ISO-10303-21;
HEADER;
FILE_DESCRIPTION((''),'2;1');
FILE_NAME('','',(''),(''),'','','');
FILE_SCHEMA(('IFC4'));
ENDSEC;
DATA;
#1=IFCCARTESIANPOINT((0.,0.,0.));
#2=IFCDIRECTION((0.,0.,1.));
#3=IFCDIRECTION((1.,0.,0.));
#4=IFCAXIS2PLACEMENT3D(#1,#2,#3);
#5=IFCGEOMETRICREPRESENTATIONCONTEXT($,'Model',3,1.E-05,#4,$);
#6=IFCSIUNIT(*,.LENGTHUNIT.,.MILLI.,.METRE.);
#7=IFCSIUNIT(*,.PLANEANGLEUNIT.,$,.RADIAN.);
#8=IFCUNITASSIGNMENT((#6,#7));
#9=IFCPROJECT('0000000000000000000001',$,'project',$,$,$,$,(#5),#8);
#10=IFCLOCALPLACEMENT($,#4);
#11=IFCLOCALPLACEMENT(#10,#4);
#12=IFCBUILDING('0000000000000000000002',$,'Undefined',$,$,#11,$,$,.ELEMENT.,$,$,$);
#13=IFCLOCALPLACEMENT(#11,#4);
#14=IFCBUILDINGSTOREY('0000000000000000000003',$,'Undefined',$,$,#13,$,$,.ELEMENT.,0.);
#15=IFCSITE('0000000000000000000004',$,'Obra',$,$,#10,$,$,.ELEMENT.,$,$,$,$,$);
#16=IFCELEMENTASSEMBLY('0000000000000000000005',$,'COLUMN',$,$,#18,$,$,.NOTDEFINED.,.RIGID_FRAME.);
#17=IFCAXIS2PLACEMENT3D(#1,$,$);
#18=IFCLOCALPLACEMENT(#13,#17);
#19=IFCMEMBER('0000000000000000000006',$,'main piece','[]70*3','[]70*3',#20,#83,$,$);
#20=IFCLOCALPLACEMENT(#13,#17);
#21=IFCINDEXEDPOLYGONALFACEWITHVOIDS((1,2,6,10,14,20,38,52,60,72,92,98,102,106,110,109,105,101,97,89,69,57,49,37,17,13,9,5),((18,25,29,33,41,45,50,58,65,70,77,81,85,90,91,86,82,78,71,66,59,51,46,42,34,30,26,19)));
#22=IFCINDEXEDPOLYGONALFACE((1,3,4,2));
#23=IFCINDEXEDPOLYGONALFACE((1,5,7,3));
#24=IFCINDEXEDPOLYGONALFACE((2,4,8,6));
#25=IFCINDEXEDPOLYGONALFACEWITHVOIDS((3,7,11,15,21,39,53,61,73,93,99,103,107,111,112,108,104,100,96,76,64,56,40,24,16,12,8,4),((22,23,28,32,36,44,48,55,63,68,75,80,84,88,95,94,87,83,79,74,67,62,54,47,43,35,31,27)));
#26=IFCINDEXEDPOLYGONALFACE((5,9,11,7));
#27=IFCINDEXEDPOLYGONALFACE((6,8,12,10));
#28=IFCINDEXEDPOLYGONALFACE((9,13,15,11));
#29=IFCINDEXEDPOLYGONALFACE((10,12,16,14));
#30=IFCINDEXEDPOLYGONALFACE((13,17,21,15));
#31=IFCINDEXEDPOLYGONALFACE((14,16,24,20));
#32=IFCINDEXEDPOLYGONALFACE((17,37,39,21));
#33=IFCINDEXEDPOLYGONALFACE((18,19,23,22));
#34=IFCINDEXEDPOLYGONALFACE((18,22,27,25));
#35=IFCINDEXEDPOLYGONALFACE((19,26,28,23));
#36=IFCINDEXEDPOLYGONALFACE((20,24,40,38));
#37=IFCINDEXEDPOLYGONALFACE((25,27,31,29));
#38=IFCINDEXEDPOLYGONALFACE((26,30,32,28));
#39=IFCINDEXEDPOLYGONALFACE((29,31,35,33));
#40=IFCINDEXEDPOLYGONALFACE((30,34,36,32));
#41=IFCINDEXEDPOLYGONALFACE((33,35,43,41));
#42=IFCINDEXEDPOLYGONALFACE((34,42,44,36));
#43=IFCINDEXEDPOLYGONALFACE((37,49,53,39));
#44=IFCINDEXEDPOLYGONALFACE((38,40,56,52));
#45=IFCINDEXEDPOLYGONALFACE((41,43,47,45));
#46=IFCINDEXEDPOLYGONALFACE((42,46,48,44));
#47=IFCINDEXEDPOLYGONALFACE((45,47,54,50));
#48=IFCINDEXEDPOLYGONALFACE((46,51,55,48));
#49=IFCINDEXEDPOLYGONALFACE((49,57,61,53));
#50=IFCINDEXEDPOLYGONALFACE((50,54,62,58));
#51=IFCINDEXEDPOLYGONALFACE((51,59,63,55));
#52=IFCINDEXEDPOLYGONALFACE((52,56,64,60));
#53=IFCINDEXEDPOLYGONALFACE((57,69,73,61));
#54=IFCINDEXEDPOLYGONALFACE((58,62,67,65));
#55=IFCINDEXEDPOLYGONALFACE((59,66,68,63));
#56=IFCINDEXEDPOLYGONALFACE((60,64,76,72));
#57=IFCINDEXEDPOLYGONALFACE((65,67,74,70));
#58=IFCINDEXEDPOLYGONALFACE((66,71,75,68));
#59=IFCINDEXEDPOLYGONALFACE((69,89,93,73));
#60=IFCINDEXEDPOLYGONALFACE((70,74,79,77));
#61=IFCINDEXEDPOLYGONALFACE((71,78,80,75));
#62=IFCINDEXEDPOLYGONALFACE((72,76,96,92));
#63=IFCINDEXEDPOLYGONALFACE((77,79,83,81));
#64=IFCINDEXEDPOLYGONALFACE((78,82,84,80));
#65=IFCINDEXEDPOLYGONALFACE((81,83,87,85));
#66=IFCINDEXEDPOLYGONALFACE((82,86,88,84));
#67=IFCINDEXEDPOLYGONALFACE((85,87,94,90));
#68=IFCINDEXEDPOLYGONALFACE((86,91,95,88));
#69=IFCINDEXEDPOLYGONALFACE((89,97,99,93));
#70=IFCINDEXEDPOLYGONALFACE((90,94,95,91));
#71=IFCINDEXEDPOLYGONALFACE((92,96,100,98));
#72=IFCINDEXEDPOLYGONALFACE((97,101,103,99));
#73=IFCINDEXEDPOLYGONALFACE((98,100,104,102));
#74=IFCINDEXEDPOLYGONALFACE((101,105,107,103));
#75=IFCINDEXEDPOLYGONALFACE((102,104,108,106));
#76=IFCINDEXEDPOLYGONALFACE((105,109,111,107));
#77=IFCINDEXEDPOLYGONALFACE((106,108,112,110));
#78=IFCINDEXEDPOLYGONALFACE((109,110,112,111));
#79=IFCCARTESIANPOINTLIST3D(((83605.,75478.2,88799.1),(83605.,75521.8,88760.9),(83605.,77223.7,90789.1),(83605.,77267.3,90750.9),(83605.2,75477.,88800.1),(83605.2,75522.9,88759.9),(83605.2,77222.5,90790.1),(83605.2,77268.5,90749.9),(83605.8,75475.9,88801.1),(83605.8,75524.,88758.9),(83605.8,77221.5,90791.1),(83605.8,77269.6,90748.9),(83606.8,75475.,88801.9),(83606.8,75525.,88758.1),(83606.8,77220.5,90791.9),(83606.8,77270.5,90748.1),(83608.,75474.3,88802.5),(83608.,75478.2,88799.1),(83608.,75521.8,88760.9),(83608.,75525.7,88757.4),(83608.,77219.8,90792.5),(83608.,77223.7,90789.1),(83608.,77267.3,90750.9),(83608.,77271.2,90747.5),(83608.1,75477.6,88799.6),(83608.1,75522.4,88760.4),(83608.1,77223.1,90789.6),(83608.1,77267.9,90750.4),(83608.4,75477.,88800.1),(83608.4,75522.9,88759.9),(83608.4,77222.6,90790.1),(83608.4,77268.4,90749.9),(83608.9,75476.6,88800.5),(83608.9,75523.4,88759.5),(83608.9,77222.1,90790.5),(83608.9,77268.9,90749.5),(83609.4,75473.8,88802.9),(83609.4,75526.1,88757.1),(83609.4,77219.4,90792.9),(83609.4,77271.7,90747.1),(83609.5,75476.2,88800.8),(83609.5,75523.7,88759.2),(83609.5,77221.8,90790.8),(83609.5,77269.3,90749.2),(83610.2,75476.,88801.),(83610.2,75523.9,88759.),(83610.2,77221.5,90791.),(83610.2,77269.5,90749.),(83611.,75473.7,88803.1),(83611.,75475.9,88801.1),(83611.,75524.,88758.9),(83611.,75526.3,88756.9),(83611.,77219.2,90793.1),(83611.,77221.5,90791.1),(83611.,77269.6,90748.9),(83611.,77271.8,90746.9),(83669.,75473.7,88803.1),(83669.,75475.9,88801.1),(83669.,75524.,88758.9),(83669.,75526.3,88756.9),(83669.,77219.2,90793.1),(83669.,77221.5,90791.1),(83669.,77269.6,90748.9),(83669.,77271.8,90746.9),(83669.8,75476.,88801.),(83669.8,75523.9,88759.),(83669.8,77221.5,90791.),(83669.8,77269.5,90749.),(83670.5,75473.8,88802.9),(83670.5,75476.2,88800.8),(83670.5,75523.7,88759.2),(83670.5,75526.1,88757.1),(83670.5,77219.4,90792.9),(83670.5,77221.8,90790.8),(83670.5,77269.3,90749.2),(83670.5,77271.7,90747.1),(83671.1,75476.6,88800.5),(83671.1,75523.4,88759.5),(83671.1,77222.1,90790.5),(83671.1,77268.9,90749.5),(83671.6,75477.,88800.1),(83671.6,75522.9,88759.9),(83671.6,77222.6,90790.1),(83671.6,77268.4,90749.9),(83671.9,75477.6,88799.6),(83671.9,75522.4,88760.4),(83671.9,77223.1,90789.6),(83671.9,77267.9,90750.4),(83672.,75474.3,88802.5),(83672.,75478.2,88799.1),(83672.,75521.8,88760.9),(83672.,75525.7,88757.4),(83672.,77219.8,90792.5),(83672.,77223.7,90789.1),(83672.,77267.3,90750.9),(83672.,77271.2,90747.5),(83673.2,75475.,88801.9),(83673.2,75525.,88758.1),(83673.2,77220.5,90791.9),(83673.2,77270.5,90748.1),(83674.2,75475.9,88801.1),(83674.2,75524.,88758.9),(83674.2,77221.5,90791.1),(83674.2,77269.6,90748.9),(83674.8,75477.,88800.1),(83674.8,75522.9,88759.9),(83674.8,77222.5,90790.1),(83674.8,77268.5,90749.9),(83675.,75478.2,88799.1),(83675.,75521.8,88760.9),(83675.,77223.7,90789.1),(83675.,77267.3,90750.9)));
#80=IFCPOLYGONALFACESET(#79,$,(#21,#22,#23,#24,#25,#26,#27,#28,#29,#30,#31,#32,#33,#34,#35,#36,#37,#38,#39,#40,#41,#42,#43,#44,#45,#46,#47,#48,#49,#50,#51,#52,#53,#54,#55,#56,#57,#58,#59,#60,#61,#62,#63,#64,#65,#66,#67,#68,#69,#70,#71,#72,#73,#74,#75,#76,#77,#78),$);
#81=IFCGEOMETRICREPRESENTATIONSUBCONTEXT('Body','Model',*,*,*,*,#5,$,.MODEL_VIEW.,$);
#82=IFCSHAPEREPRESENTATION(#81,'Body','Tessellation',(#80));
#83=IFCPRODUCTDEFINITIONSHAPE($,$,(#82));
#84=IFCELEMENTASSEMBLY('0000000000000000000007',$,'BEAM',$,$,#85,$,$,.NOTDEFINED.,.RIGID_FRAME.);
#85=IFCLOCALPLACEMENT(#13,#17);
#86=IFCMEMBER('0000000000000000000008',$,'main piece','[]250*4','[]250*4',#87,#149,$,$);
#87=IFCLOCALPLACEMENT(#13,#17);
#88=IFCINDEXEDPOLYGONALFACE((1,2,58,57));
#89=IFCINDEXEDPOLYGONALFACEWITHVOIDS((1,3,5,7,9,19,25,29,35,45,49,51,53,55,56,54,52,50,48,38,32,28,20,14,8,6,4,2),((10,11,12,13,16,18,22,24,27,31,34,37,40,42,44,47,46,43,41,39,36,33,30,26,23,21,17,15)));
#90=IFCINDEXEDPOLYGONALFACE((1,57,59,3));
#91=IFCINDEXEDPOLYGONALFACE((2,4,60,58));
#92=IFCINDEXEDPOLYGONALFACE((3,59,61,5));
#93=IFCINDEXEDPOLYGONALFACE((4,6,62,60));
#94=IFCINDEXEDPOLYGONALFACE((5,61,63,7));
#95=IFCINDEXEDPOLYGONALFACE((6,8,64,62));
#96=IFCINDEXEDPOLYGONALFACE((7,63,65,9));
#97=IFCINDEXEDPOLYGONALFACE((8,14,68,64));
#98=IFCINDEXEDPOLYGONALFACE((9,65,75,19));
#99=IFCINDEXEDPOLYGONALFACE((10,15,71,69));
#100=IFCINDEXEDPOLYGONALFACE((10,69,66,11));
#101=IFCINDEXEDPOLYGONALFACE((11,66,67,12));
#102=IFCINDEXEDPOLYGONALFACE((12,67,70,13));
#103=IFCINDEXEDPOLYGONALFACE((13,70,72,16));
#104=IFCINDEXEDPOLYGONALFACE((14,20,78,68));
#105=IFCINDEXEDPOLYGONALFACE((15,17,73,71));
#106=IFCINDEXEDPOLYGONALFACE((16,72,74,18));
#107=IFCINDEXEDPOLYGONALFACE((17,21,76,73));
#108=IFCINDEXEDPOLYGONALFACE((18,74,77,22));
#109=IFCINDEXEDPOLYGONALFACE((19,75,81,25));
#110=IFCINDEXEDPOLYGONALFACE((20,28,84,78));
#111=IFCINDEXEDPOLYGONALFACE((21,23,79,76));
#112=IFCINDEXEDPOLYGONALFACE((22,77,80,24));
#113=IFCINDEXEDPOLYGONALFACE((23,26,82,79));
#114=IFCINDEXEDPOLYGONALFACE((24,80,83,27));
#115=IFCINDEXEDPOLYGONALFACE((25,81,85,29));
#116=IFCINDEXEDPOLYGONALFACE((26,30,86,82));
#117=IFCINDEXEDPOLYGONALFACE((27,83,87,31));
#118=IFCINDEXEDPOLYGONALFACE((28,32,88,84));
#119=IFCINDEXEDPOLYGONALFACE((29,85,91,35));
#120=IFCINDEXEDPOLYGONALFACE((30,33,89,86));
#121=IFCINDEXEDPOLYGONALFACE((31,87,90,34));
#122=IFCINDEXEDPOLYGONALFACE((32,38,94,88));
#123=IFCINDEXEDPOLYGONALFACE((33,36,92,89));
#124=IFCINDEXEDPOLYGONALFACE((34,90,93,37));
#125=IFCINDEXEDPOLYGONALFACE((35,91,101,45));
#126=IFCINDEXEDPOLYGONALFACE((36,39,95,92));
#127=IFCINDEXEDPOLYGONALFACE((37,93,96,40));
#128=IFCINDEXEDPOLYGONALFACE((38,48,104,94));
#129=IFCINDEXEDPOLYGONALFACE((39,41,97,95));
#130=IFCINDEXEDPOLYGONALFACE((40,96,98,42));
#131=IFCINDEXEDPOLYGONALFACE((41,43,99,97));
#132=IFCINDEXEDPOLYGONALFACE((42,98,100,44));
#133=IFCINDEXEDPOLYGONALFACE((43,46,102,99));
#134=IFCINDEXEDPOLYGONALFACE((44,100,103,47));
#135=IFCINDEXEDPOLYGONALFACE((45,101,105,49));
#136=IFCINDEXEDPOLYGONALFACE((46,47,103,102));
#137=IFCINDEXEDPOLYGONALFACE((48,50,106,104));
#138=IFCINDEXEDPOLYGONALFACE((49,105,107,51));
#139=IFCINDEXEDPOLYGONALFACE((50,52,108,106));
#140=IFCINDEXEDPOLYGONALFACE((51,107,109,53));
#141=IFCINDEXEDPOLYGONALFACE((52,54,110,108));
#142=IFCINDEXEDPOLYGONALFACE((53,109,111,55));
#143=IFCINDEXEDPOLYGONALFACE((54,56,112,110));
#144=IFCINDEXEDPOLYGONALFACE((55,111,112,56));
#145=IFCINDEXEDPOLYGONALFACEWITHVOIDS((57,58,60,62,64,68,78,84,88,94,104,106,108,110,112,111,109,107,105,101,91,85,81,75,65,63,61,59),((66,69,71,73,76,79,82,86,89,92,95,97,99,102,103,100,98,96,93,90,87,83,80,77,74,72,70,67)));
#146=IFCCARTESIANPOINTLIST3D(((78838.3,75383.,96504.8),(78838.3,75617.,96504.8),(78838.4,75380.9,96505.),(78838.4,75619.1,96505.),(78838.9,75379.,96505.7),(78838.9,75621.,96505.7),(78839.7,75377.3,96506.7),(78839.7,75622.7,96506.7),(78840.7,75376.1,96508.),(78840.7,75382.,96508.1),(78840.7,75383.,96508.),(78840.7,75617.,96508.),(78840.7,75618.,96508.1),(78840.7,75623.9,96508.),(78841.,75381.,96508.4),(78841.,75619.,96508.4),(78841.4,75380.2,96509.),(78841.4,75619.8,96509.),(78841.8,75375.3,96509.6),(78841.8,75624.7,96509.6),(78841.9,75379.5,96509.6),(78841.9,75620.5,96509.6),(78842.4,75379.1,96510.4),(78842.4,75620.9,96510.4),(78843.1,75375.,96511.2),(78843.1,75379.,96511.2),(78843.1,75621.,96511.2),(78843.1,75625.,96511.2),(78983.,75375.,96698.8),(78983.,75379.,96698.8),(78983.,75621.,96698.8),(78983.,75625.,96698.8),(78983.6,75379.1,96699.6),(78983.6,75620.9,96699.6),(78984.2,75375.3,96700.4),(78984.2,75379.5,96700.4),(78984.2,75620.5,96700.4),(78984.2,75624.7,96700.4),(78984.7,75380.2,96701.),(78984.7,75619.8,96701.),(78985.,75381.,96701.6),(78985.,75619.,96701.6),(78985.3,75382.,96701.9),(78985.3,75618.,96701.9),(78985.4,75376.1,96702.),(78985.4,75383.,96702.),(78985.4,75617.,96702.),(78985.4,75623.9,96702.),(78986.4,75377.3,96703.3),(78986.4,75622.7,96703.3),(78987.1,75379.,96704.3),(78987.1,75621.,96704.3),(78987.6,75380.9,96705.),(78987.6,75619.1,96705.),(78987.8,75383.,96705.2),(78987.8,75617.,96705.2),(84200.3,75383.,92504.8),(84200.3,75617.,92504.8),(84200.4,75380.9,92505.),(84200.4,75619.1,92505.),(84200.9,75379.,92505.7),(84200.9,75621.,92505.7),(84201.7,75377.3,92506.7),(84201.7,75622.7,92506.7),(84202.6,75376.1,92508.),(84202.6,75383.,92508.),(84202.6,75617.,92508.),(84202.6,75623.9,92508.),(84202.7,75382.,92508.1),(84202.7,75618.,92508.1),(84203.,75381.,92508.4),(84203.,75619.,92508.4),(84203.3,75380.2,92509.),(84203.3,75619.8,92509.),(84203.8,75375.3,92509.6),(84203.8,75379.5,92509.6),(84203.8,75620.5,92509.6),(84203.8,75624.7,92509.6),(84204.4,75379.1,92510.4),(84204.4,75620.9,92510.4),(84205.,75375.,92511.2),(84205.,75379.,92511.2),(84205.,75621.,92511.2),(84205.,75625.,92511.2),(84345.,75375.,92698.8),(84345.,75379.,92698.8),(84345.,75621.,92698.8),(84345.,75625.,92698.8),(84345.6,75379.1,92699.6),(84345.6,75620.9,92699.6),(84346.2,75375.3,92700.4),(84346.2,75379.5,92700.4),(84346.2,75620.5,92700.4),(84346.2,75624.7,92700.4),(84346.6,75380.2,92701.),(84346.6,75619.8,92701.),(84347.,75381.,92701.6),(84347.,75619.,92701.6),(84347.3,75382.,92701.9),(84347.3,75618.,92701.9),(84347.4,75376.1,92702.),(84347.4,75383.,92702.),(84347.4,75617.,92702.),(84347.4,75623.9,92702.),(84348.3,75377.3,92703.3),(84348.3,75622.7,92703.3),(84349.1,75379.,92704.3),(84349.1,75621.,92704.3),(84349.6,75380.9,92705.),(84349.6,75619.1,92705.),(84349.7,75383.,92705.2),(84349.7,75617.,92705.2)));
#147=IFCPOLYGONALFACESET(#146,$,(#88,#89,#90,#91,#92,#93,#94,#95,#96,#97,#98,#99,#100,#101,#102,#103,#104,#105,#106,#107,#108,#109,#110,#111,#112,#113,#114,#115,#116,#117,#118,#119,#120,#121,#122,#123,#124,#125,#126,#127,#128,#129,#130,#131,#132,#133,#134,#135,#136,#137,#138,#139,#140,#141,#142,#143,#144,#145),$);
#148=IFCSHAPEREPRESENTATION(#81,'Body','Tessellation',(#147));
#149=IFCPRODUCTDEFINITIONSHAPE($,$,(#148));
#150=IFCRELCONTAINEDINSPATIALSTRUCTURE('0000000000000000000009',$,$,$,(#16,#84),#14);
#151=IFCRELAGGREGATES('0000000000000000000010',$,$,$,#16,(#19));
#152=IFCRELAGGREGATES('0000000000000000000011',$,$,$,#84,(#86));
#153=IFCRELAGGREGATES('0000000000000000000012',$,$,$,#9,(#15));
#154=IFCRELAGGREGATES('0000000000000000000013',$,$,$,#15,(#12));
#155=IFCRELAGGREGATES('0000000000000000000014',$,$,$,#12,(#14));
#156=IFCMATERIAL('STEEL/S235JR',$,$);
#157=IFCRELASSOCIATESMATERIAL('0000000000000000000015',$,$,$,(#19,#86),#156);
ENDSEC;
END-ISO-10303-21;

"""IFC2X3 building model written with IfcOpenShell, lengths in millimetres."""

from ifc_helpers import new_model, si_unit, frame, origin_with_axes, origin_2d_with_axis, place, context, subcontext, project, spatial, hollow_rectangle, extrude, material, element, aggregate, save


model = new_model("IFC2X3")

# Units and contexts
model_context = context("Model", 3, precision=1e-05, world=origin_with_axes())
body_context = subcontext(model_context, "Body", "Model", "MODEL_VIEW")
ifc_project = project(units=[si_unit("LENGTHUNIT", "METRE", prefix="MILLI"), si_unit("PLANEANGLEUNIT", "RADIAN")], contexts=[model_context])

# Site, building, storey
site_placement = place(None, origin_with_axes())
site = spatial("IfcSite", under=ifc_project, at=site_placement, Name="Obra", CompositionType="ELEMENT")
building_placement = place(site_placement, origin_with_axes())
building = spatial("IfcBuilding", under=site, at=building_placement, Name="Undefined", CompositionType="ELEMENT")
storey_placement = place(building_placement, origin_with_axes())
storey = spatial("IfcBuildingStorey", under=building, at=storey_placement, Name="Undefined", CompositionType="ELEMENT", Elevation=0.0)

# Shared definitions
ifc_material = material(Name="STEEL/S235JR")

# Element assemblies, members
assembly_1_placement = place(storey_placement, origin_with_axes())
assembly_1 = element("IfcElementAssembly", 1, at=assembly_1_placement, inside=storey, Name="COLUMN", AssemblyPlace="NOTDEFINED", PredefinedType="RIGID_FRAME")
member_1_placement = place(assembly_1_placement, frame((83640.0, 75500.0, 88780.0), z_axis=(-1.0, 0.0, 0.0), x_axis=(0.0, 0.659423, 0.751772)))
member_1 = element("IfcMember", 2, at=member_1_placement, material=ifc_material, Name="main piece", Description="[]70*3", ObjectType="[]70*3", context=body_context, shape_type="SweptSolid", body=[
    extrude(hollow_rectangle(XDim=70.0, YDim=70.0, WallThickness=3.0, InnerFilletRadius=3.0, OuterFilletRadius=6.0, at=origin_2d_with_axis()), frame((2647.1, 0.0, 0.0), z_axis=(-1.0, 0.0, 0.0), x_axis=(0.0, -1.0, 0.0)), (0.0, 0.0, 1.0), 2647.1),
])
aggregate(assembly_1, [member_1])
assembly_2_placement = place(storey_placement, origin_with_axes())
assembly_2 = element("IfcElementAssembly", 3, at=assembly_2_placement, inside=storey, Name="BEAM", AssemblyPlace="NOTDEFINED", PredefinedType="RIGID_FRAME")
member_2_placement = place(assembly_2_placement, frame((78913.0, 75500.0, 96605.0), z_axis=(0.597942, 0.0, 0.801539), x_axis=(0.801539, 0.0, -0.597942)))
member_2 = element("IfcMember", 4, at=member_2_placement, material=ifc_material, Name="main piece", Description="[]250*4", ObjectType="[]250*4", context=body_context, shape_type="SweptSolid", body=[
    extrude(hollow_rectangle(XDim=250.0, YDim=250.0, WallThickness=4.0, InnerFilletRadius=4.0, OuterFilletRadius=8.0, at=origin_2d_with_axis()), frame((6689.6, 0.0, 0.0), z_axis=(-1.0, 0.0, 0.0), x_axis=(0.0, -1.0, 0.0)), (0.0, 0.0, 1.0), 6689.6),
])
aggregate(assembly_2, [member_2])

save(model, "model.ifc")
